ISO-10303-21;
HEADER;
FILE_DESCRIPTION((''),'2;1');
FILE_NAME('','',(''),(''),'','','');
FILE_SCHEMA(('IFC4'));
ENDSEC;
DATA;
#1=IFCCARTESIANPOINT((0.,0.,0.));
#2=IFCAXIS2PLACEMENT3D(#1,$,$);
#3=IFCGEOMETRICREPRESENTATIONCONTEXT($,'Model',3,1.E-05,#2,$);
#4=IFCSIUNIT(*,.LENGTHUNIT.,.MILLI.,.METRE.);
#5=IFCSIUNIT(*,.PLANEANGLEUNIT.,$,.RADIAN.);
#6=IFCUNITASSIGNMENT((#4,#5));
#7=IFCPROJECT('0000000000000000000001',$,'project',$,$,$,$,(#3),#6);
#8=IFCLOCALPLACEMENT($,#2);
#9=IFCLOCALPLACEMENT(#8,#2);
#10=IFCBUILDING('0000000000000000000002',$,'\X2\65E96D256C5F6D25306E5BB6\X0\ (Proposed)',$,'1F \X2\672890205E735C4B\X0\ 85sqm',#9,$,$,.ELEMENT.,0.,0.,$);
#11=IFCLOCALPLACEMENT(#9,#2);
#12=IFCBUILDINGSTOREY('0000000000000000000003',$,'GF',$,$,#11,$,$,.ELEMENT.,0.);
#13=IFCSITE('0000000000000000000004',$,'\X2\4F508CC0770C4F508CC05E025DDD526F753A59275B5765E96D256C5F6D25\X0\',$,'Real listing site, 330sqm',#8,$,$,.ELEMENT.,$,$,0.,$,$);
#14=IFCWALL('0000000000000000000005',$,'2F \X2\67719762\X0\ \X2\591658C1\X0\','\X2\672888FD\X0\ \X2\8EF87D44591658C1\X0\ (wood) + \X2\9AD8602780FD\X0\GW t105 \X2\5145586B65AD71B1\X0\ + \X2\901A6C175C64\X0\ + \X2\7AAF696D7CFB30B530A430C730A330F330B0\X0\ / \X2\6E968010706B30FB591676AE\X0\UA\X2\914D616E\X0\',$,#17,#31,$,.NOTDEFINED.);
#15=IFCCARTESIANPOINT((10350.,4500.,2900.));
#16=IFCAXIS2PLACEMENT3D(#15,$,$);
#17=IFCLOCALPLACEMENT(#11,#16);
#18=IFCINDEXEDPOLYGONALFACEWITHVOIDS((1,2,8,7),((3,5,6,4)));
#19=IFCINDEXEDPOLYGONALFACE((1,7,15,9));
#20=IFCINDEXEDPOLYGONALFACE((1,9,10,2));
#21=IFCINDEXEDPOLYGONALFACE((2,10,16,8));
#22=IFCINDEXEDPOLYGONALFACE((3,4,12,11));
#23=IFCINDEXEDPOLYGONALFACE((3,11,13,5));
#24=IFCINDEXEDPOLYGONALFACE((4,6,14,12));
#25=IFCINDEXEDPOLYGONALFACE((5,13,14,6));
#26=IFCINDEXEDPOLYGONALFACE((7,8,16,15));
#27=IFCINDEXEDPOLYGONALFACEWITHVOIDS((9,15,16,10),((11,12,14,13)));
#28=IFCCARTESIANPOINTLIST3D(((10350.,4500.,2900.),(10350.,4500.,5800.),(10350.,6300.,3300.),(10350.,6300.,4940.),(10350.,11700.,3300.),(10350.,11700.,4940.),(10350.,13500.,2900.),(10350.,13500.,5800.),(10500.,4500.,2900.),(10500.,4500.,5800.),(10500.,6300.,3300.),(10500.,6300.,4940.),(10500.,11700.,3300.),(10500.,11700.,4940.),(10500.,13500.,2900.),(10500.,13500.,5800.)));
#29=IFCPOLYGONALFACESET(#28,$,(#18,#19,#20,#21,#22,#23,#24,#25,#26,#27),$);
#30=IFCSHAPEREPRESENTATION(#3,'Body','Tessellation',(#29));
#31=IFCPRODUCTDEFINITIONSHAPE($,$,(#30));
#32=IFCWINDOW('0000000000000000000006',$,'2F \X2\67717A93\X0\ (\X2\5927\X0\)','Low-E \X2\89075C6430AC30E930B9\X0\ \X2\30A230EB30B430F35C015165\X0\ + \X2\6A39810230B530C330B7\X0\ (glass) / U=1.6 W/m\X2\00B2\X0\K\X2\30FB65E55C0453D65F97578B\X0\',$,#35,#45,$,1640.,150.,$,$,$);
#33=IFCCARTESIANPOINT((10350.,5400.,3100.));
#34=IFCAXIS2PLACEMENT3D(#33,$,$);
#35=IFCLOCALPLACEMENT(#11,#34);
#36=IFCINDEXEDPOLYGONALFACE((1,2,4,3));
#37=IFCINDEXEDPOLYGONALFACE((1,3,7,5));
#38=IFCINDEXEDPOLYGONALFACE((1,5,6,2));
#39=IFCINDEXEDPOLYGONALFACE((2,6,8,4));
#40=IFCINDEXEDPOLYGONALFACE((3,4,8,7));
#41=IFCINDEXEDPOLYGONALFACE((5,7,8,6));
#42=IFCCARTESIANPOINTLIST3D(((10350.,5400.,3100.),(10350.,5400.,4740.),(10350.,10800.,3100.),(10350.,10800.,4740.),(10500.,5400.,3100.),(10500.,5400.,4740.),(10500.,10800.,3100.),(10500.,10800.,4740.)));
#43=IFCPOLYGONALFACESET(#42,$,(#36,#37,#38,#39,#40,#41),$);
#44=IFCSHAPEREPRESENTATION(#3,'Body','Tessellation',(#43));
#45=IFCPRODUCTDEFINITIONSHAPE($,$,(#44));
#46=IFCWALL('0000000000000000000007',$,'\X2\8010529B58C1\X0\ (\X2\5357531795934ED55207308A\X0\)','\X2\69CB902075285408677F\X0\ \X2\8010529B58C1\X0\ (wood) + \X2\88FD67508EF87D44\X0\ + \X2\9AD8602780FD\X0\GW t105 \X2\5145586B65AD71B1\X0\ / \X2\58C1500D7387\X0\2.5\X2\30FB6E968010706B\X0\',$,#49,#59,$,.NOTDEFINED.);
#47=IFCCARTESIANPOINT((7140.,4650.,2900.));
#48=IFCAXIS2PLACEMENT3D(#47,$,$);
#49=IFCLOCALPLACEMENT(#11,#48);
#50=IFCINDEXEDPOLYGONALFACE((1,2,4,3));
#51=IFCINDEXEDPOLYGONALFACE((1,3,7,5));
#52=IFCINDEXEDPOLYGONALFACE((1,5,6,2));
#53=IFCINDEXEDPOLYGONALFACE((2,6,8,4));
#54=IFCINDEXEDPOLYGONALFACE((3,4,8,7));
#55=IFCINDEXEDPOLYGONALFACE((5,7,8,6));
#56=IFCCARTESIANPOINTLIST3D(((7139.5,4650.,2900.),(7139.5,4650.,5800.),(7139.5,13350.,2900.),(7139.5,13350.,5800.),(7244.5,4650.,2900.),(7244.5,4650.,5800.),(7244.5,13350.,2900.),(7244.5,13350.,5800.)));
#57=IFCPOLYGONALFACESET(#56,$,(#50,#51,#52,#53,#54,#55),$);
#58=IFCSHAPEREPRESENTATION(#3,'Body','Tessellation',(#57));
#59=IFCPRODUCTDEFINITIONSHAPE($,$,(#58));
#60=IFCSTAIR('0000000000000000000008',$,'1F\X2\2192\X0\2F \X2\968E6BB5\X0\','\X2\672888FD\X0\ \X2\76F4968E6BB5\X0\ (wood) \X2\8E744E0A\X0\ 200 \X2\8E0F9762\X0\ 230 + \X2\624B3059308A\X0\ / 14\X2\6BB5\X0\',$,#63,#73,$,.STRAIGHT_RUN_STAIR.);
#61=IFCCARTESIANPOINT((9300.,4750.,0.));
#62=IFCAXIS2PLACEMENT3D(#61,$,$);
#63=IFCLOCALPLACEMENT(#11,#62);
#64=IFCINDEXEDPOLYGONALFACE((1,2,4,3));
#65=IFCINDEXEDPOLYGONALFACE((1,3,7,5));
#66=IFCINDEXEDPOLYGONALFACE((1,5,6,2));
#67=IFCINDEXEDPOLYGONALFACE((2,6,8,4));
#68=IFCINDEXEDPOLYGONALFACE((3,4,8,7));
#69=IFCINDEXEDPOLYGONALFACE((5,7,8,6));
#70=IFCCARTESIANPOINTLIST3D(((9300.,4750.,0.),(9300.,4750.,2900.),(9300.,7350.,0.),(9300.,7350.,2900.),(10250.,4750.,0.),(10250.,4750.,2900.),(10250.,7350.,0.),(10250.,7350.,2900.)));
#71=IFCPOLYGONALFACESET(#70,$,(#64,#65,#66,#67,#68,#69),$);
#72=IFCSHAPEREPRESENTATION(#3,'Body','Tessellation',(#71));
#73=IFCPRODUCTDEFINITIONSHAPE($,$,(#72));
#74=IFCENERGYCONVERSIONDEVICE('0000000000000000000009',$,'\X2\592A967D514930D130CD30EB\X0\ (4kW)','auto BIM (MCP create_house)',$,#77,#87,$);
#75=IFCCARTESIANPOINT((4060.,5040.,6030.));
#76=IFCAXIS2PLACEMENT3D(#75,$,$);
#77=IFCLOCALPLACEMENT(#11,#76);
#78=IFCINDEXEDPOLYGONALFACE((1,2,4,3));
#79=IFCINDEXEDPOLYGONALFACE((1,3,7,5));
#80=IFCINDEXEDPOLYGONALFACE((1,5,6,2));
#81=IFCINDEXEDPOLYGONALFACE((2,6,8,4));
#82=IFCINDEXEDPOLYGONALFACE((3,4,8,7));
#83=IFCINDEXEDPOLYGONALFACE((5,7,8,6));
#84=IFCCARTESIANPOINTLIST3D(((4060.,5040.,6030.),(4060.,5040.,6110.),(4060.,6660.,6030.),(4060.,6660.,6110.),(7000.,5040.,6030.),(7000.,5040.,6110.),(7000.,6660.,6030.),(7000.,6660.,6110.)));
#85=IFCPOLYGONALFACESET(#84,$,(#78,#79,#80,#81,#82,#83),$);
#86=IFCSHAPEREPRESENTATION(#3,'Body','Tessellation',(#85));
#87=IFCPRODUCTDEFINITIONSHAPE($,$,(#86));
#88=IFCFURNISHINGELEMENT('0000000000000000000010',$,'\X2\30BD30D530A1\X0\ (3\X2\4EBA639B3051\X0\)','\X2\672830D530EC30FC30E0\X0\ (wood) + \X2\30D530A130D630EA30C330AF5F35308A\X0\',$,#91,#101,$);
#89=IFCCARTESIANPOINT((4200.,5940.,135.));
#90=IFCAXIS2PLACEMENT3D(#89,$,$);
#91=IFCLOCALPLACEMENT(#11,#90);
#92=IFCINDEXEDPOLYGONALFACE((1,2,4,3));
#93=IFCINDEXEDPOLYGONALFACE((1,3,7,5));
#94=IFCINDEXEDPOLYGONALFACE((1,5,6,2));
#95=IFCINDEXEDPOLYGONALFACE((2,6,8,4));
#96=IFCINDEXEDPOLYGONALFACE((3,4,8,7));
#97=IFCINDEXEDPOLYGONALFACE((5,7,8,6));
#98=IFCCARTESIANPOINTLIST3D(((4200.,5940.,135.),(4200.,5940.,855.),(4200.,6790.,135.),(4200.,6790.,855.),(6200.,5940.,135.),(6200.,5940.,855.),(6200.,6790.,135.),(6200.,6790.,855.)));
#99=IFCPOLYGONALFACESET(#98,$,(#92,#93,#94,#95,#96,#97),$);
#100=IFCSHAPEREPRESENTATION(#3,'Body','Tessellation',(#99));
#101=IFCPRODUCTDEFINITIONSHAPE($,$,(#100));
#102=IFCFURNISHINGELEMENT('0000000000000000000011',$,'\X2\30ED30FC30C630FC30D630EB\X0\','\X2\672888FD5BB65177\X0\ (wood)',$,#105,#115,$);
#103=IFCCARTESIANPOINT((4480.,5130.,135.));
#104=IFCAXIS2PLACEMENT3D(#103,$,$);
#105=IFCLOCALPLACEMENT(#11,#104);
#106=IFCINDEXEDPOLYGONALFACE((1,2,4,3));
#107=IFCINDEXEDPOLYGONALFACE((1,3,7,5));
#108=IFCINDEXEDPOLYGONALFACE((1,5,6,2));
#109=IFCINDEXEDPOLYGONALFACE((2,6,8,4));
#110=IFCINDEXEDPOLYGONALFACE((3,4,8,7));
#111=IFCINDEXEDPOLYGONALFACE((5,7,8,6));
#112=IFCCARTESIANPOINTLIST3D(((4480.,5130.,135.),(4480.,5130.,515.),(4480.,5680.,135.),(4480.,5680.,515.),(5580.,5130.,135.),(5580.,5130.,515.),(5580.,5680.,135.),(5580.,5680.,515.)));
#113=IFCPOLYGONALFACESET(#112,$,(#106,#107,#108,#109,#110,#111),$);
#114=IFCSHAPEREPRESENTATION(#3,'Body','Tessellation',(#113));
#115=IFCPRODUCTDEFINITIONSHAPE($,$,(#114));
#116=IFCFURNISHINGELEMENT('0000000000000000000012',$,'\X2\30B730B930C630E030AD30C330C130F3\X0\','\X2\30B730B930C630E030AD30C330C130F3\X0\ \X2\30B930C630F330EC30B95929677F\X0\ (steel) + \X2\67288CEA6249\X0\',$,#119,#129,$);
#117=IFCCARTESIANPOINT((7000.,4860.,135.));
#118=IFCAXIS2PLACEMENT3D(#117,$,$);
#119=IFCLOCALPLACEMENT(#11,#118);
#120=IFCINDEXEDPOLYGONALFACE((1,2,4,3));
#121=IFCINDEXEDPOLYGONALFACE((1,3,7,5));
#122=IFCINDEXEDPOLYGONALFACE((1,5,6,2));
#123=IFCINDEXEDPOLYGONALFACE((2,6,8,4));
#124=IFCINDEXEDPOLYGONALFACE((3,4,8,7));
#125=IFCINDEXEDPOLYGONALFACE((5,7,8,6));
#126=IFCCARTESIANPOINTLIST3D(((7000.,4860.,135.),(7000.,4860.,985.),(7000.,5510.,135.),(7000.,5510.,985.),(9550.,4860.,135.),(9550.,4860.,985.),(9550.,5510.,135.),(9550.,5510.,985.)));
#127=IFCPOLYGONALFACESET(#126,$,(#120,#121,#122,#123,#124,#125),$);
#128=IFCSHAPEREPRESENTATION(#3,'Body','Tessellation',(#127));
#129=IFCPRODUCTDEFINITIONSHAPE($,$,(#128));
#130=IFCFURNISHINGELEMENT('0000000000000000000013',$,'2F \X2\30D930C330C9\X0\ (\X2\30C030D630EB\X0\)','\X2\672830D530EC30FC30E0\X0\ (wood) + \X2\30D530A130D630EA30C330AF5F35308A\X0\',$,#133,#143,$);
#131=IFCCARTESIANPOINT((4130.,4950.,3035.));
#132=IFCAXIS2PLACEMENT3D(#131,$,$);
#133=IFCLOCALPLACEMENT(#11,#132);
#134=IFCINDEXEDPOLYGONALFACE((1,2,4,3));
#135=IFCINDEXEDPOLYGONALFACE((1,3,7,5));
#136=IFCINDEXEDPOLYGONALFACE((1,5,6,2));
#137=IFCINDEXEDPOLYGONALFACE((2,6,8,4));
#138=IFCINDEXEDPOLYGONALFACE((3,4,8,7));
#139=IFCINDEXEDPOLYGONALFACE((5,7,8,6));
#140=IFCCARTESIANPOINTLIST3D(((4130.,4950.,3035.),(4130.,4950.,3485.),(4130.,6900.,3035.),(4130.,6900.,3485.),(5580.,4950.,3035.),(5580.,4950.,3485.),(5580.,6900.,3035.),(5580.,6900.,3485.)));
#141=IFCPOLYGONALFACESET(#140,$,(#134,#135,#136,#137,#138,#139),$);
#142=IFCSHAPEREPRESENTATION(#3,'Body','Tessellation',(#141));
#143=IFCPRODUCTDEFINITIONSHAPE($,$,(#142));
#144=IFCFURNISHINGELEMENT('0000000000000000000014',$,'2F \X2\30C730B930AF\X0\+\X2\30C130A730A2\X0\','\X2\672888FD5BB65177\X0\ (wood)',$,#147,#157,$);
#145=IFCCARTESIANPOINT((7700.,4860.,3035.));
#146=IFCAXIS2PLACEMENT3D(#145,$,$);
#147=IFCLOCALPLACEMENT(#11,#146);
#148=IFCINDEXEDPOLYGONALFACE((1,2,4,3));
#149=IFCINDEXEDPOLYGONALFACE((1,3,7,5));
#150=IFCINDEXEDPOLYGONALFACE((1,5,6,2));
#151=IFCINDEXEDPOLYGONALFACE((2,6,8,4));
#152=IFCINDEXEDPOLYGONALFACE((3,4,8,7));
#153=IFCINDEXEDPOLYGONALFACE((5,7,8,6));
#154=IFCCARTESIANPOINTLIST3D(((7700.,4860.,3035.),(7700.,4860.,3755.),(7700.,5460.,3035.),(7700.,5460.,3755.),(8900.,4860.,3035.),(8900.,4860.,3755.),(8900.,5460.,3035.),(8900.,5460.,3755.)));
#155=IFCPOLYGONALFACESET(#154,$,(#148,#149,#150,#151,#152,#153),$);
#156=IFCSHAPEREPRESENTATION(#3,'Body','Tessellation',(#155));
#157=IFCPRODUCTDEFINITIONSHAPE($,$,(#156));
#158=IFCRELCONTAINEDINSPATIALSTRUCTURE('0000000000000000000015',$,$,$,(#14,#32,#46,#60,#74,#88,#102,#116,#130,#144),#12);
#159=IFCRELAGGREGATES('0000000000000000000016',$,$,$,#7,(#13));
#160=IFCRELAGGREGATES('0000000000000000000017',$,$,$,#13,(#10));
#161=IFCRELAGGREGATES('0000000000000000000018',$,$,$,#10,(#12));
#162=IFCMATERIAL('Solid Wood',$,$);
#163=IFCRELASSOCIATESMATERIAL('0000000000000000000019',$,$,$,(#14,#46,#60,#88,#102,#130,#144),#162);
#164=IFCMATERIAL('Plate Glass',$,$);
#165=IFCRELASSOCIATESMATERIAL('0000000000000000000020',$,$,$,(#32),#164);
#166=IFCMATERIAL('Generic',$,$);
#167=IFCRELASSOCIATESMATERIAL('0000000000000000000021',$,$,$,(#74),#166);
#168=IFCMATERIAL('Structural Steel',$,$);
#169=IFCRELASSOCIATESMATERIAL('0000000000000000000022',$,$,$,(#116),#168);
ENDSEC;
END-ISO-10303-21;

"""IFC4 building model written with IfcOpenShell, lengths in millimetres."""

from ifc_helpers import new_model, si_unit, frame, frame_2d, origin, place, context, project, spatial, rectangle, extrude, material, element, fill, save


model = new_model("IFC4")

# Units and contexts
model_context = context("Model", 3, precision=1e-05, world=origin())
ifc_project = project(units=[si_unit("LENGTHUNIT", "METRE", prefix="MILLI"), si_unit("PLANEANGLEUNIT", "RADIAN")], contexts=[model_context])

# Site, building, storey
site_placement = place(None, origin())
site = spatial("IfcSite", under=ifc_project, at=site_placement, Name="佐賀県佐賀市川副町大字早津江津", ObjectType="Real listing site, 330sqm", CompositionType="ELEMENT", RefElevation=0.0)
building_placement = place(site_placement, origin())
building = spatial("IfcBuilding", under=site, at=building_placement, Name="早津江津の家 (Proposed)", ObjectType="1F 木造平屋 85sqm", CompositionType="ELEMENT", ElevationOfRefHeight=0.0, ElevationOfTerrain=0.0)
storey_placement = place(building_placement, origin())
storey = spatial("IfcBuildingStorey", under=building, at=storey_placement, Name="GF", CompositionType="ELEMENT", Elevation=0.0)

# Shared definitions
ifc_material_1 = material(Name="Solid Wood")
ifc_material_2 = material(Name="Plate Glass")

# Wall, opening, window
wall_1_placement = place(storey_placement, frame((10350.0, 4500.0, 2900.0)))
wall_1 = element("IfcWall", 1, at=wall_1_placement, inside=storey, material=ifc_material_1, Name="2F 東面 外壁", Description="木製 軸組外壁 (wood) + 高性能GW t105 充填断熱 + 通気層 + 窯業系サイディング / 準耐火・外皮UA配慮", PredefinedType="NOTDEFINED", context=model_context, shape_type="SweptSolid", body=[
    extrude(rectangle(XDim=150.0, YDim=9000.0, at=frame_2d((75.0, 4500.0))), frame((10350.0, 4500.0, 2900.0)), (0.0, 0.0, 1.0), 2900.0),
])
opening_1_placement = place(storey_placement, frame((10350.0, 5400.0, 3100.0)))
opening_1 = element("IfcOpeningElement", 2, at=opening_1_placement, cuts=wall_1, PredefinedType="NOTDEFINED", context=model_context, shape_type="SweptSolid", body=[
    extrude(rectangle(XDim=150.0, YDim=5400.0, at=frame_2d((75.0, 2700.0))), frame((10350.0, 5400.0, 3100.0)), (0.0, 0.0, 1.0), 1640.0),
])
window_1_placement = place(storey_placement, frame((10350.0, 5400.0, 3100.0)))
window_1 = element("IfcWindow", 3, at=window_1_placement, inside=storey, material=ifc_material_2, Name="2F 東窓 (大)", Description="Low-E 複層ガラス アルゴン封入 + 樹脂サッシ (glass) / U=1.6 W/m²K・日射取得型", OverallHeight=1640.0, OverallWidth=150.0, context=model_context, shape_type="SweptSolid", body=[
    extrude(rectangle(XDim=150.0, YDim=5400.0, at=frame_2d((75.0, 2700.0))), frame((10350.0, 5400.0, 3100.0)), (0.0, 0.0, 1.0), 1640.0),
])
fill(opening_1, window_1)

# Wall
wall_2_placement = place(storey_placement, frame((7140.0, 4650.0, 2900.0)))
element("IfcWall", 4, at=wall_2_placement, inside=storey, material=ifc_material_1, Name="耐力壁 (南北間仕切り)", Description="構造用合板 耐力壁 (wood) + 製材軸組 + 高性能GW t105 充填断熱 / 壁倍率2.5・準耐火", PredefinedType="NOTDEFINED", context=model_context, shape_type="SweptSolid", body=[
    extrude(rectangle(XDim=105.0, YDim=8700.0, at=frame_2d((52.0, 4350.0))), frame((7140.0, 4650.0, 2900.0)), (0.0, 0.0, 1.0), 2900.0),
])

# Stair
stair_placement = place(storey_placement, frame((9300.0, 4750.0, 0.0)))
element("IfcStair", 5, at=stair_placement, inside=storey, material=ifc_material_1, Name="1F→2F 階段", Description="木製 直階段 (wood) 蹴上 200 踏面 230 + 手すり / 14段", PredefinedType="STRAIGHT_RUN_STAIR", context=model_context, shape_type="SweptSolid", body=[
    extrude(rectangle(XDim=950.0, YDim=2600.0, at=frame_2d((475.0, 1300.0))), frame((9300.0, 4750.0, 0.0)), (0.0, 0.0, 1.0), 2900.0),
])

# Energy conversion device
ifc_material_3 = material(Name="Generic")
energy_conversion_device_placement = place(storey_placement, frame((4060.0, 5040.0, 6030.0)))
element("IfcEnergyConversionDevice", 6, at=energy_conversion_device_placement, inside=storey, material=ifc_material_3, Name="太陽光パネル (4kW)", Description="auto BIM (MCP create_house)", context=model_context, shape_type="SweptSolid", body=[
    extrude(rectangle(XDim=2940.0, YDim=1620.0, at=frame_2d((1470.0, 810.0))), frame((4060.0, 5040.0, 6030.0)), (0.0, 0.0, 1.0), 80.0),
])

# Furnishing elements
furnishing_1_placement = place(storey_placement, frame((4200.0, 5940.0, 135.0)))
element("IfcFurnishingElement", 7, at=furnishing_1_placement, inside=storey, material=ifc_material_1, Name="ソファ (3人掛け)", Description="木フレーム (wood) + ファブリック張り", context=model_context, shape_type="SweptSolid", body=[
    extrude(rectangle(XDim=2000.0, YDim=850.0, at=frame_2d((1000.0, 425.0))), frame((4200.0, 5940.0, 135.0)), (0.0, 0.0, 1.0), 720.0),
])
furnishing_2_placement = place(storey_placement, frame((4480.0, 5130.0, 135.0)))
element("IfcFurnishingElement", 8, at=furnishing_2_placement, inside=storey, material=ifc_material_1, Name="ローテーブル", Description="木製家具 (wood)", context=model_context, shape_type="SweptSolid", body=[
    extrude(rectangle(XDim=1100.0, YDim=550.0, at=frame_2d((550.0, 275.0))), frame((4480.0, 5130.0, 135.0)), (0.0, 0.0, 1.0), 380.0),
])
ifc_material_4 = material(Name="Structural Steel")
furnishing_3_placement = place(storey_placement, frame((7000.0, 4860.0, 135.0)))
element("IfcFurnishingElement", 9, at=furnishing_3_placement, inside=storey, material=ifc_material_4, Name="システムキッチン", Description="システムキッチン ステンレス天板 (steel) + 木質扉", context=model_context, shape_type="SweptSolid", body=[
    extrude(rectangle(XDim=2550.0, YDim=650.0, at=frame_2d((1275.0, 325.0))), frame((7000.0, 4860.0, 135.0)), (0.0, 0.0, 1.0), 850.0),
])
furnishing_4_placement = place(storey_placement, frame((4130.0, 4950.0, 3035.0)))
element("IfcFurnishingElement", 10, at=furnishing_4_placement, inside=storey, material=ifc_material_1, Name="2F ベッド (ダブル)", Description="木フレーム (wood) + ファブリック張り", context=model_context, shape_type="SweptSolid", body=[
    extrude(rectangle(XDim=1450.0, YDim=1950.0, at=frame_2d((725.0, 975.0))), frame((4130.0, 4950.0, 3035.0)), (0.0, 0.0, 1.0), 450.0),
])
furnishing_5_placement = place(storey_placement, frame((7700.0, 4860.0, 3035.0)))
element("IfcFurnishingElement", 11, at=furnishing_5_placement, inside=storey, material=ifc_material_1, Name="2F デスク+チェア", Description="木製家具 (wood)", context=model_context, shape_type="SweptSolid", body=[
    extrude(rectangle(XDim=1200.0, YDim=600.0, at=frame_2d((600.0, 300.0))), frame((7700.0, 4860.0, 3035.0)), (0.0, 0.0, 1.0), 720.0),
])

save(model, "model.ifc")
